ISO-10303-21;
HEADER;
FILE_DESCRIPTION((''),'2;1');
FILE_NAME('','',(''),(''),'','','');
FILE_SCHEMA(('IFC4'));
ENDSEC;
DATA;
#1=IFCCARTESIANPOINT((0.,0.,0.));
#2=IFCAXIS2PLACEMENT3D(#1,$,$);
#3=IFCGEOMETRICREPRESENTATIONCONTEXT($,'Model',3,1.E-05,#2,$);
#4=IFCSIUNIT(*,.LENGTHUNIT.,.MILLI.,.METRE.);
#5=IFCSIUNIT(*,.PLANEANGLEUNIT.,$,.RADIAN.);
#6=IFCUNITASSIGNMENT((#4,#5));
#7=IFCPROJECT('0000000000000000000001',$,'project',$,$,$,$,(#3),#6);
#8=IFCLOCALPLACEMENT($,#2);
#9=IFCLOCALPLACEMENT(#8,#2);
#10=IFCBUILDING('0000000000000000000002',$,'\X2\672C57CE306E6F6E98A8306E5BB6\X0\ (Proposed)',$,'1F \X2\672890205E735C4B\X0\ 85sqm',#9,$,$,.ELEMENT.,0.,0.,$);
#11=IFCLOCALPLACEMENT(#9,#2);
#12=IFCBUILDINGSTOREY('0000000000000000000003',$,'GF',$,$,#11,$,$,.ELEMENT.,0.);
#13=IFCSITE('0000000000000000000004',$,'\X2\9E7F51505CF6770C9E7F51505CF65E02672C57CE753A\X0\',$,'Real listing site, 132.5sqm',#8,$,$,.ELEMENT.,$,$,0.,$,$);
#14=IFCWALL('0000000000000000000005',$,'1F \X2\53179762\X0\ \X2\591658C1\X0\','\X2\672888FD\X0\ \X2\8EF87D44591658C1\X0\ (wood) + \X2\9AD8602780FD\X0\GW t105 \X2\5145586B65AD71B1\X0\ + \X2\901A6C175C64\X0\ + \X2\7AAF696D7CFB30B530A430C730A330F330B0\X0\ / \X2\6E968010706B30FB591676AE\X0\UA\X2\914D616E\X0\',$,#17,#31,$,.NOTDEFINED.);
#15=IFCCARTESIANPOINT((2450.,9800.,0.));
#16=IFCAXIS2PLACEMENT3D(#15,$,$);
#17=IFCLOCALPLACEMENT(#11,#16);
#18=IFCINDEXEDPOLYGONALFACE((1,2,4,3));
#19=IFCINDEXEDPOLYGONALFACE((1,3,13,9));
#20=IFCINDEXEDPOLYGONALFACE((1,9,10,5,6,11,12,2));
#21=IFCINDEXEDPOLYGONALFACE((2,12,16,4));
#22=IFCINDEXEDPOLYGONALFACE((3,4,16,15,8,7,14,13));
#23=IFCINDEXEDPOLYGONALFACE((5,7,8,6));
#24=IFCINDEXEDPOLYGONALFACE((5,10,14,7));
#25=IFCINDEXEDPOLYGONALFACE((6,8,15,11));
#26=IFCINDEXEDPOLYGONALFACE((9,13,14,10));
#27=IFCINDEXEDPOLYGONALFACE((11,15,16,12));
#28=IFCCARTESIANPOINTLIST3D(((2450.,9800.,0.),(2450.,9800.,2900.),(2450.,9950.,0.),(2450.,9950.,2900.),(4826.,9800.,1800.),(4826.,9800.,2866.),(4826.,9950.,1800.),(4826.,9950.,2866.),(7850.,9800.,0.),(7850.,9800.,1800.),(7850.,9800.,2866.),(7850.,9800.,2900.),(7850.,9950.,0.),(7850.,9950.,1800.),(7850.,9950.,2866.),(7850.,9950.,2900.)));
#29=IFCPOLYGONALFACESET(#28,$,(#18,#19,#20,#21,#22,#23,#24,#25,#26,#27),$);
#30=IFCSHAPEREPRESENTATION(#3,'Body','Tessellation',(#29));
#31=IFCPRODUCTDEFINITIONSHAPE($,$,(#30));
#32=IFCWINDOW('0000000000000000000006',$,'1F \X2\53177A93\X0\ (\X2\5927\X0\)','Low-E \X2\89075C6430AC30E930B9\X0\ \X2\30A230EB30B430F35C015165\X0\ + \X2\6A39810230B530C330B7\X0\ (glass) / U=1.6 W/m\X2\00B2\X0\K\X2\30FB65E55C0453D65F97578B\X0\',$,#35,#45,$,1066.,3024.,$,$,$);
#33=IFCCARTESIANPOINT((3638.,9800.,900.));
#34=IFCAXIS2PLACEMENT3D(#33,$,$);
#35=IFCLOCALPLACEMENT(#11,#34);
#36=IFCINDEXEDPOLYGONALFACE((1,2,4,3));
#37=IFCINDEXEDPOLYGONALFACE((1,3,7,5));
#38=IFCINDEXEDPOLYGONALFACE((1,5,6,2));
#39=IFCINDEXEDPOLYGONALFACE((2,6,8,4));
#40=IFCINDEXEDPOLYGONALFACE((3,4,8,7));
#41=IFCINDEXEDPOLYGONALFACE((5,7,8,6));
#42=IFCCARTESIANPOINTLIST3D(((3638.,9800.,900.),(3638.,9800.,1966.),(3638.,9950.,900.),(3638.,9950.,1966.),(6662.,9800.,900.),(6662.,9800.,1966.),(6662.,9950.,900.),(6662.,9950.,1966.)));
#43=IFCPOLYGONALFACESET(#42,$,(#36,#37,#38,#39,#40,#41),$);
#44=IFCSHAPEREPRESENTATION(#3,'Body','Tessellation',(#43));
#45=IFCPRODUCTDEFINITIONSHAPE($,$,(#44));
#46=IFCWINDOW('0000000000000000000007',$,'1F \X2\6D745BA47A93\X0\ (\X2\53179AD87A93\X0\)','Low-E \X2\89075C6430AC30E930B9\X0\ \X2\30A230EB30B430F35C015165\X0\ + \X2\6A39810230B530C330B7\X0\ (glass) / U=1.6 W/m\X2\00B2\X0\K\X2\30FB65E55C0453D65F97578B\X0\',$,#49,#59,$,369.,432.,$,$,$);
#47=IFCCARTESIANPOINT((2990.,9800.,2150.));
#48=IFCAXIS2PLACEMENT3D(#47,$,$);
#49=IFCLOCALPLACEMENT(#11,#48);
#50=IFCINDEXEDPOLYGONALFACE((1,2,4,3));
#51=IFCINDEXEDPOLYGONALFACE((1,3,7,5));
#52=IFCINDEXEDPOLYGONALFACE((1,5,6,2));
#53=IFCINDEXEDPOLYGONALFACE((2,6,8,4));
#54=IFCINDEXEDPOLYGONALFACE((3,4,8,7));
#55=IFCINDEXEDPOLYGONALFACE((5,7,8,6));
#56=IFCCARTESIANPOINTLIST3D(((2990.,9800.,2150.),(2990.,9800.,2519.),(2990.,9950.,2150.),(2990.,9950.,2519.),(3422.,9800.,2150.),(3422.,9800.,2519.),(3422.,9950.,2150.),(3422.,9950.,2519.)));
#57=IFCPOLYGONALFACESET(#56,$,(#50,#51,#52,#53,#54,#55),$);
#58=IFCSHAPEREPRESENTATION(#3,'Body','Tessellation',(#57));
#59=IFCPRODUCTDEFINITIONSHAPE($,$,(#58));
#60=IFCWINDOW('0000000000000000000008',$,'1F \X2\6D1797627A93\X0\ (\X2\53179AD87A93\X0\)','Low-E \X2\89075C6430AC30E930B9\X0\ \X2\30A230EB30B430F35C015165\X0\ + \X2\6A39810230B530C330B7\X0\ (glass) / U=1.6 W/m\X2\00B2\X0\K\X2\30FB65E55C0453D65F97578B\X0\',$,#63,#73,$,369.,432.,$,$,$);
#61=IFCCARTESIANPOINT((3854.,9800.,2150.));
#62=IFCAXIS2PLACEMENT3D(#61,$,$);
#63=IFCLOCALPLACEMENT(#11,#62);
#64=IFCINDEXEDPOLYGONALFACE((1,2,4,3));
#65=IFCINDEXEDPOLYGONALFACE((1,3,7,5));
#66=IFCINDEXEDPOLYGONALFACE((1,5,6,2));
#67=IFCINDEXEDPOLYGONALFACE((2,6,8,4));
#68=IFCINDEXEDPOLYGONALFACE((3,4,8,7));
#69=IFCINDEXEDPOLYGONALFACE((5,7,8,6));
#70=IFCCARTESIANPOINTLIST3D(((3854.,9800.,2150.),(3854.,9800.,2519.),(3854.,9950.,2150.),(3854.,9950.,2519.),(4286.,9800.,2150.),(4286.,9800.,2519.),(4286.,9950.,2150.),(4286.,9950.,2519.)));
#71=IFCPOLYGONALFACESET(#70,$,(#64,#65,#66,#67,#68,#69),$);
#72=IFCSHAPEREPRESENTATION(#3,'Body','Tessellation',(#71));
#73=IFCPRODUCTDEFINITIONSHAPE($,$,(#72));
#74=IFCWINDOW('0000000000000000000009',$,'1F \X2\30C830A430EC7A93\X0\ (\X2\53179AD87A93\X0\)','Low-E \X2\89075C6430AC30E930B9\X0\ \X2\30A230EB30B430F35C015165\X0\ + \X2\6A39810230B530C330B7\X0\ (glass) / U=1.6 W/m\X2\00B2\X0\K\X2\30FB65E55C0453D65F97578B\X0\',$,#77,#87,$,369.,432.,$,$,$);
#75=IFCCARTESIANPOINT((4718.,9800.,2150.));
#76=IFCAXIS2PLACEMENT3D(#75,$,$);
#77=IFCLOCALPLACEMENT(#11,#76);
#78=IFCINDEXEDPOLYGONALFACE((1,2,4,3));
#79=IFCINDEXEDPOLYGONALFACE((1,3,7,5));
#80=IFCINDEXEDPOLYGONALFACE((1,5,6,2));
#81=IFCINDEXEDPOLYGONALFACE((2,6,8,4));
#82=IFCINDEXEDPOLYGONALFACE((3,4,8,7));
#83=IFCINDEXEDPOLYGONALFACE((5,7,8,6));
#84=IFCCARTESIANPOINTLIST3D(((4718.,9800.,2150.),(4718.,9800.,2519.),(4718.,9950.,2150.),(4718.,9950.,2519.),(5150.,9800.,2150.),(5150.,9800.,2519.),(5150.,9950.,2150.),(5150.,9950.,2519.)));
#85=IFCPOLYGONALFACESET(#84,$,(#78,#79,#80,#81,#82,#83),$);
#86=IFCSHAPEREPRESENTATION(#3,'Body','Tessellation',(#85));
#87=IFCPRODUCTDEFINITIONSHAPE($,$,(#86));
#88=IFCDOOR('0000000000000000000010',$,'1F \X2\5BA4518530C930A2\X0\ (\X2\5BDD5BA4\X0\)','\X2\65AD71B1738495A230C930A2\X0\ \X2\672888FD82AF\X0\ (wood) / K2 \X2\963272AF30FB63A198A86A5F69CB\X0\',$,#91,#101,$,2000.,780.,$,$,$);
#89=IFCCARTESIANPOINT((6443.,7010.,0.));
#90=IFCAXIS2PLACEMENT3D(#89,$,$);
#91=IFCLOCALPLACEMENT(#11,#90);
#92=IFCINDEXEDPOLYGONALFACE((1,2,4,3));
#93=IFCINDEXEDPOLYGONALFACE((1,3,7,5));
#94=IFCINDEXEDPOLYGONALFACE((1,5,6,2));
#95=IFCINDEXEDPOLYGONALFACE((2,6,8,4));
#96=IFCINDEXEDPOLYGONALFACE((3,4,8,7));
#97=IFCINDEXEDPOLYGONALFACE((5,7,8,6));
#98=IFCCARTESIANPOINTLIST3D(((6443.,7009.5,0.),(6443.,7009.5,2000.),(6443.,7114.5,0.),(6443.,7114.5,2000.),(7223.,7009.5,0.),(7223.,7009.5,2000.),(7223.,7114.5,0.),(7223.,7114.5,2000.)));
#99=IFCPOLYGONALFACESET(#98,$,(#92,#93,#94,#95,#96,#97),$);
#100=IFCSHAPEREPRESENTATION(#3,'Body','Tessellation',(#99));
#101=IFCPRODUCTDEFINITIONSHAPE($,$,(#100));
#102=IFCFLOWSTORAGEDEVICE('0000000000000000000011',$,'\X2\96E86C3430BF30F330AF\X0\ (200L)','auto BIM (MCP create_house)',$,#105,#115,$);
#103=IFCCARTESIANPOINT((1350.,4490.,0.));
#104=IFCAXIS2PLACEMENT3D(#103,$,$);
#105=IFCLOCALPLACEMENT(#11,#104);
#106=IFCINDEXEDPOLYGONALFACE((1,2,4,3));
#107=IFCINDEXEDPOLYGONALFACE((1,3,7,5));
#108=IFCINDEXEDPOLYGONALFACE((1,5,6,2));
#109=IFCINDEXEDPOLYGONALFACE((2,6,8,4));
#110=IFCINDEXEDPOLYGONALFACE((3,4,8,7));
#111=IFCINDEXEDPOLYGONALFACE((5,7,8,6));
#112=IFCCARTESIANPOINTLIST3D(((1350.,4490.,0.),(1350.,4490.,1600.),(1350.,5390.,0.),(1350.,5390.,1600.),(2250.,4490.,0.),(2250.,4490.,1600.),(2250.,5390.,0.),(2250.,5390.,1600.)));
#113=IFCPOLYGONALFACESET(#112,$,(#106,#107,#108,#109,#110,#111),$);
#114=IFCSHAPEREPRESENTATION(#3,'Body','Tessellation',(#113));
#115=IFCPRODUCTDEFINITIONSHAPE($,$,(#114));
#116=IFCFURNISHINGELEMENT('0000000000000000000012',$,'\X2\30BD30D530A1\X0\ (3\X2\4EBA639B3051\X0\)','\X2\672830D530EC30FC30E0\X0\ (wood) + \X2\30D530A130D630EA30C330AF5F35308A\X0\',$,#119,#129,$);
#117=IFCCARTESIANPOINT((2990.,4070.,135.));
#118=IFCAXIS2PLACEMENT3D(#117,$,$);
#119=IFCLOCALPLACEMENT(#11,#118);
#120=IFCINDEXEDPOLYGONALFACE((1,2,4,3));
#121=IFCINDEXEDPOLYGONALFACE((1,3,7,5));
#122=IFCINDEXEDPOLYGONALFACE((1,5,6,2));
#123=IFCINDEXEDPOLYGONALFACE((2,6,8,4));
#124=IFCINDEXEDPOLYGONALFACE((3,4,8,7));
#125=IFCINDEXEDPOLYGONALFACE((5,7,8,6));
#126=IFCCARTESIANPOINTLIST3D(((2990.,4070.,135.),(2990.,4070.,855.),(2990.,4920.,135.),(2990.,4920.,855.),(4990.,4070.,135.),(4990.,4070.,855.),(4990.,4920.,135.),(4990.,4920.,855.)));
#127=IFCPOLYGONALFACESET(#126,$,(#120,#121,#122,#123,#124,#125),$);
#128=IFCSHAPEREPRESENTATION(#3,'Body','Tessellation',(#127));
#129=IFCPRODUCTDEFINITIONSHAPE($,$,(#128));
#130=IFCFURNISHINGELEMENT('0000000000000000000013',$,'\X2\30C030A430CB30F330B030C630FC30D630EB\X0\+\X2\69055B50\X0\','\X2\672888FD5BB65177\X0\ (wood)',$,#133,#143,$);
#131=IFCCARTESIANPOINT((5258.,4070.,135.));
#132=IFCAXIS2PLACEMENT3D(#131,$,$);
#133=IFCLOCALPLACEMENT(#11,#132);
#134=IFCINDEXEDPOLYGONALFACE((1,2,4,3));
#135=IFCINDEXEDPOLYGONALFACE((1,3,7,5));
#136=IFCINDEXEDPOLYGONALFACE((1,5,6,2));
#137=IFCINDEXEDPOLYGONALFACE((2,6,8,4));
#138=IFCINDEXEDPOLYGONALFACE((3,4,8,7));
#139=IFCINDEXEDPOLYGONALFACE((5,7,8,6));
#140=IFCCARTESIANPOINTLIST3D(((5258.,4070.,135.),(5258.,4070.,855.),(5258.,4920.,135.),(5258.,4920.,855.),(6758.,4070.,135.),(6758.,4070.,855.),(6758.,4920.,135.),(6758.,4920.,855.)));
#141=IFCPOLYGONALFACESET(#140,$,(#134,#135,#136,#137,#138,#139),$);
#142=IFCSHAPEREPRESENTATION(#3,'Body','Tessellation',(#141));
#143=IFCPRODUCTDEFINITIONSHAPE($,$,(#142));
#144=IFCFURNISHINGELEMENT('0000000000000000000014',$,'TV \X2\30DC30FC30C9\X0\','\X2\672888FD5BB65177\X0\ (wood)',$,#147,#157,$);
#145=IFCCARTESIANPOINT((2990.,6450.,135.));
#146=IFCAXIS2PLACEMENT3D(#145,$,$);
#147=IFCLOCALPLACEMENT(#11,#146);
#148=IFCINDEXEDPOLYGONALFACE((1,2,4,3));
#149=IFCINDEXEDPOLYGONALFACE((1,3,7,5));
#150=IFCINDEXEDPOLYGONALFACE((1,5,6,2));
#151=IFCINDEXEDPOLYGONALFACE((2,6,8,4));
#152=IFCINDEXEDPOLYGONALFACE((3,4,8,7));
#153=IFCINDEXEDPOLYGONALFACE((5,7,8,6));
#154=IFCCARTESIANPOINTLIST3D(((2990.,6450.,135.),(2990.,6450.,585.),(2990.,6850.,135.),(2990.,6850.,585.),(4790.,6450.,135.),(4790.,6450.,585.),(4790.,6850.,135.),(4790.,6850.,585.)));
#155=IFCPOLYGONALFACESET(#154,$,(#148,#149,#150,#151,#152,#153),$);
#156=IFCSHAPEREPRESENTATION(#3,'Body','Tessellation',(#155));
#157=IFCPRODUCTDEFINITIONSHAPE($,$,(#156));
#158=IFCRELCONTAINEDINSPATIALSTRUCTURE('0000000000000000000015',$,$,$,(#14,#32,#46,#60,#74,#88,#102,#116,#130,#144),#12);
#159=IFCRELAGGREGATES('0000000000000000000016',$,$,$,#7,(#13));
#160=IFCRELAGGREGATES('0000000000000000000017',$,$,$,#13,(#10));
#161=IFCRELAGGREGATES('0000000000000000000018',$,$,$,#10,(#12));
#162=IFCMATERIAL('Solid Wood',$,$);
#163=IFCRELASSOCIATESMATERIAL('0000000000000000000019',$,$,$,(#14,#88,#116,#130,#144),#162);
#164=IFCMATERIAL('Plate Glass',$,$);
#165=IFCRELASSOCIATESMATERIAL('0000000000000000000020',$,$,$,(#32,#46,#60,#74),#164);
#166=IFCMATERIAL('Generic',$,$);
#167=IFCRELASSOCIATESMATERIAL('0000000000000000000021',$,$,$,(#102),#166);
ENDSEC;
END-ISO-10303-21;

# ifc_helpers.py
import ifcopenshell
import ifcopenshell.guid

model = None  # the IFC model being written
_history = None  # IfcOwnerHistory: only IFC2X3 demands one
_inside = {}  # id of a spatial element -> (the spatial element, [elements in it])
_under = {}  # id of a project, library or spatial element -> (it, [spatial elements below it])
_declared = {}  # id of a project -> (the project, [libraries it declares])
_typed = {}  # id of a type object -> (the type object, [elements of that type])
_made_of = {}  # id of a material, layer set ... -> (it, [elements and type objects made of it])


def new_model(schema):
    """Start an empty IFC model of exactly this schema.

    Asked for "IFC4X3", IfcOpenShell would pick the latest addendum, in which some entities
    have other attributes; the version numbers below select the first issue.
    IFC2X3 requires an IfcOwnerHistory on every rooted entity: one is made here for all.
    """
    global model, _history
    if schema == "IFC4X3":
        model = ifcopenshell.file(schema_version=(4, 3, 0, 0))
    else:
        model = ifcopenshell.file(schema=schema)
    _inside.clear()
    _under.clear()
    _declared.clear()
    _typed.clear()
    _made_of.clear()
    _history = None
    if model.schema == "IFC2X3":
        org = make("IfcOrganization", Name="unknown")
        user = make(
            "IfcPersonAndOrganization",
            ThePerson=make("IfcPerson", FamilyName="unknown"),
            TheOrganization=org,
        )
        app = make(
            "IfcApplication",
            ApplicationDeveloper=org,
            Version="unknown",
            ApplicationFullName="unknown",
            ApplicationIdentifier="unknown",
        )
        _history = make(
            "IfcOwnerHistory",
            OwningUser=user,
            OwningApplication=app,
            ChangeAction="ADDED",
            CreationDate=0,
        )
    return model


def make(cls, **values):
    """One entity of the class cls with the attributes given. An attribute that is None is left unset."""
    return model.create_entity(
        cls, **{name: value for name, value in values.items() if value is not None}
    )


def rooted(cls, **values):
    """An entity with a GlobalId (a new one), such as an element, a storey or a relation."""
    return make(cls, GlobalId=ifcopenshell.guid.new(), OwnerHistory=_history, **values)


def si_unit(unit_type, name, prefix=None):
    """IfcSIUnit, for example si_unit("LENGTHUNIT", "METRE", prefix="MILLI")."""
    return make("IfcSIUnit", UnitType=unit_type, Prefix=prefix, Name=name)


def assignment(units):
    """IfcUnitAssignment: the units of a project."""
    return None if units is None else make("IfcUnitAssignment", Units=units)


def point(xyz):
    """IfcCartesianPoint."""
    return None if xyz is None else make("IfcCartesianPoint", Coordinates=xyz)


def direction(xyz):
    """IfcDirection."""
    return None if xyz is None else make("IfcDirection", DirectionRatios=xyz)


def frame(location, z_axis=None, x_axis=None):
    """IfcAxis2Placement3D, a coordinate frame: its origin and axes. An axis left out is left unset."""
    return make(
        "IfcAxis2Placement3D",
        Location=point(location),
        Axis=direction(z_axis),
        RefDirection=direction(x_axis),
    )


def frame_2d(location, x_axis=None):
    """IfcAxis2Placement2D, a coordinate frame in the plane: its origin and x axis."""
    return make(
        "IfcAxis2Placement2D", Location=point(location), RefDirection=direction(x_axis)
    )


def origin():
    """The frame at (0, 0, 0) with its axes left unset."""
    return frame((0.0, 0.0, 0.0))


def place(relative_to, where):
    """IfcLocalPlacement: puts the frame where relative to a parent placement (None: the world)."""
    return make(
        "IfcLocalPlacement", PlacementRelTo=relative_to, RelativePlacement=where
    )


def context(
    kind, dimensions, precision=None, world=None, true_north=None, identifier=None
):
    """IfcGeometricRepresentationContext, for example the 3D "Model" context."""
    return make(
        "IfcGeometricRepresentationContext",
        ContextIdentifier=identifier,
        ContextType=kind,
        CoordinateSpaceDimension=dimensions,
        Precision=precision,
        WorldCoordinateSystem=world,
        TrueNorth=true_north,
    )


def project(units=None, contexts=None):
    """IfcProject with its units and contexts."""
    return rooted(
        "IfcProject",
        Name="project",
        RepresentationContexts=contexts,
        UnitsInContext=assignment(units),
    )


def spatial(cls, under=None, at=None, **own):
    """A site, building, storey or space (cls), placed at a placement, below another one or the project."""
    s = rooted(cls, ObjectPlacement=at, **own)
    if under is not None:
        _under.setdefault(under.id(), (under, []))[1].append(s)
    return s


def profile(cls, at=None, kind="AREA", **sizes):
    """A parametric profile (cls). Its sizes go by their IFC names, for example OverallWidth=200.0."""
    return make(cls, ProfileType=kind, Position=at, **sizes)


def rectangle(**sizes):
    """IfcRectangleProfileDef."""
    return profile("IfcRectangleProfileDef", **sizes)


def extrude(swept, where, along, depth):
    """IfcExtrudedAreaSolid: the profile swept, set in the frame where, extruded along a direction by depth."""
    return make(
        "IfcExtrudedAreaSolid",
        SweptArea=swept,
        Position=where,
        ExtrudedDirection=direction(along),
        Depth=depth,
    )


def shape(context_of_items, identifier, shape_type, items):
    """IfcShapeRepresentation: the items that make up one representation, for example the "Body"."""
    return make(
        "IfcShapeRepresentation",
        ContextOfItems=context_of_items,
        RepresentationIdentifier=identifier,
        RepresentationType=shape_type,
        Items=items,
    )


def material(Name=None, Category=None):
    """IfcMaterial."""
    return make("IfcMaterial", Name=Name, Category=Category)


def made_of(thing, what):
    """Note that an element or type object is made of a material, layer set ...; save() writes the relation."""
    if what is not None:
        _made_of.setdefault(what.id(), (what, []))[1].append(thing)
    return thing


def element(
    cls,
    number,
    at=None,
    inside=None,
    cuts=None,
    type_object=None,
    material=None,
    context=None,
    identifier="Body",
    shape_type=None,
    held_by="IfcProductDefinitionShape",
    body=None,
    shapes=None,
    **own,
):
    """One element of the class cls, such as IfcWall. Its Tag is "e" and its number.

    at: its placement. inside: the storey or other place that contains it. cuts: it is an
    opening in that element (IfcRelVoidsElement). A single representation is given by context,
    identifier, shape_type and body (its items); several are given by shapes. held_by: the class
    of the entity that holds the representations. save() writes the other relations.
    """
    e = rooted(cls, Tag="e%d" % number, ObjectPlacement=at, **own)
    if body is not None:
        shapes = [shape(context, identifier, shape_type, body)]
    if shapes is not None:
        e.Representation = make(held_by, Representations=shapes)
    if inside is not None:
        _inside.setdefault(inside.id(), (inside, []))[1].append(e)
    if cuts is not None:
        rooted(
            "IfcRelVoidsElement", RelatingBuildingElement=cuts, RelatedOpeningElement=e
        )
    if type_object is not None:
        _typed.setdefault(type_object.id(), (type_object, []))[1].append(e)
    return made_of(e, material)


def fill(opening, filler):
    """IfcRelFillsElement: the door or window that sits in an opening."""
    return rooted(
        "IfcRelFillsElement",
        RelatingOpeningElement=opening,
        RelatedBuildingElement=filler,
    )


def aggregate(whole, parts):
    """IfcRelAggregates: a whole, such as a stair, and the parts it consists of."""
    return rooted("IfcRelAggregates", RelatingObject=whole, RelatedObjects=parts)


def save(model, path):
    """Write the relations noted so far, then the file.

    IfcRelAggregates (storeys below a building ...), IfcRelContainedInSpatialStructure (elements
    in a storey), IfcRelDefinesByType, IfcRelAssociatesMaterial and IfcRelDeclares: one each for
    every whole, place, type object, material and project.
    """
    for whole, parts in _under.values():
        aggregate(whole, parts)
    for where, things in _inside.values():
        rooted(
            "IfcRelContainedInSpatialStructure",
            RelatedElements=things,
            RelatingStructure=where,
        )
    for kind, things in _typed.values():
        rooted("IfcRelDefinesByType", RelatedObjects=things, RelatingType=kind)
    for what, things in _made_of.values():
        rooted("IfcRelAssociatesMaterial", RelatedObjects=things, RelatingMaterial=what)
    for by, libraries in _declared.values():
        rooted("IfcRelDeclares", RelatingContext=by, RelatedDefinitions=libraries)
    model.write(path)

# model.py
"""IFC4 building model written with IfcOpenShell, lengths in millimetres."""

from ifc_helpers import new_model, si_unit, frame, frame_2d, origin, place, context, project, spatial, rectangle, extrude, material, element, fill, save


model = new_model("IFC4")

# Units and contexts
model_context = context("Model", 3, precision=1e-05, world=origin())
ifc_project = project(units=[si_unit("LENGTHUNIT", "METRE", prefix="MILLI"), si_unit("PLANEANGLEUNIT", "RADIAN")], contexts=[model_context])

# Site, building, storey
site_placement = place(None, origin())
site = spatial("IfcSite", under=ifc_project, at=site_placement, Name="鹿児島県鹿児島市本城町", ObjectType="Real listing site, 132.5sqm", CompositionType="ELEMENT", RefElevation=0.0)
building_placement = place(site_placement, origin())
building = spatial("IfcBuilding", under=site, at=building_placement, Name="本城の潮風の家 (Proposed)", ObjectType="1F 木造平屋 85sqm", CompositionType="ELEMENT", ElevationOfRefHeight=0.0, ElevationOfTerrain=0.0)
storey_placement = place(building_placement, origin())
storey = spatial("IfcBuildingStorey", under=building, at=storey_placement, Name="GF", CompositionType="ELEMENT", Elevation=0.0)

# Wall, openings, windows
ifc_material_1 = material(Name="Solid Wood")
wall_1_placement = place(storey_placement, frame((2450.0, 9800.0, 0.0)))
wall_1 = element("IfcWall", 1, at=wall_1_placement, inside=storey, material=ifc_material_1, Name="1F 北面 外壁", Description="木製 軸組外壁 (wood) + 高性能GW t105 充填断熱 + 通気層 + 窯業系サイディング / 準耐火・外皮UA配慮", PredefinedType="NOTDEFINED", context=model_context, shape_type="SweptSolid", body=[
    extrude(rectangle(XDim=5400.0, YDim=150.0, at=frame_2d((2700.0, 75.0))), frame((2450.0, 9800.0, 0.0)), (0.0, 0.0, 1.0), 2900.0),
])
opening_1_placement = place(storey_placement, frame((3638.0, 9800.0, 900.0)))
opening_1 = element("IfcOpeningElement", 2, at=opening_1_placement, cuts=wall_1, PredefinedType="NOTDEFINED", context=model_context, shape_type="SweptSolid", body=[
    extrude(rectangle(XDim=3024.0, YDim=150.0, at=frame_2d((1512.0, 75.0))), frame((3638.0, 9800.0, 900.0)), (0.0, 0.0, 1.0), 1066.0),
])
opening_2_placement = place(storey_placement, frame((2990.0, 9800.0, 2150.0)))
opening_2 = element("IfcOpeningElement", 3, at=opening_2_placement, cuts=wall_1, PredefinedType="NOTDEFINED", context=model_context, shape_type="SweptSolid", body=[
    extrude(rectangle(XDim=432.0, YDim=150.0, at=frame_2d((216.0, 75.0))), frame((2990.0, 9800.0, 2150.0)), (0.0, 0.0, 1.0), 369.0),
])
opening_3_placement = place(storey_placement, frame((3854.0, 9800.0, 2150.0)))
opening_3 = element("IfcOpeningElement", 4, at=opening_3_placement, cuts=wall_1, PredefinedType="NOTDEFINED", context=model_context, shape_type="SweptSolid", body=[
    extrude(rectangle(XDim=432.0, YDim=150.0, at=frame_2d((216.0, 75.0))), frame((3854.0, 9800.0, 2150.0)), (0.0, 0.0, 1.0), 369.0),
])
opening_4_placement = place(storey_placement, frame((4718.0, 9800.0, 2150.0)))
opening_4 = element("IfcOpeningElement", 5, at=opening_4_placement, cuts=wall_1, PredefinedType="NOTDEFINED", context=model_context, shape_type="SweptSolid", body=[
    extrude(rectangle(XDim=432.0, YDim=150.0, at=frame_2d((216.0, 75.0))), frame((4718.0, 9800.0, 2150.0)), (0.0, 0.0, 1.0), 369.0),
])
ifc_material_2 = material(Name="Plate Glass")
window_1_placement = place(storey_placement, frame((3638.0, 9800.0, 900.0)))
window_1 = element("IfcWindow", 6, at=window_1_placement, inside=storey, material=ifc_material_2, Name="1F 北窓 (大)", Description="Low-E 複層ガラス アルゴン封入 + 樹脂サッシ (glass) / U=1.6 W/m²K・日射取得型", OverallHeight=1066.0, OverallWidth=3024.0, context=model_context, shape_type="SweptSolid", body=[
    extrude(rectangle(XDim=3024.0, YDim=150.0, at=frame_2d((1512.0, 75.0))), frame((3638.0, 9800.0, 900.0)), (0.0, 0.0, 1.0), 1066.0),
])
fill(opening_1, window_1)
window_2_placement = place(storey_placement, frame((2990.0, 9800.0, 2150.0)))
window_2 = element("IfcWindow", 7, at=window_2_placement, inside=storey, material=ifc_material_2, Name="1F 浴室窓 (北高窓)", Description="Low-E 複層ガラス アルゴン封入 + 樹脂サッシ (glass) / U=1.6 W/m²K・日射取得型", OverallHeight=369.0, OverallWidth=432.0, context=model_context, shape_type="SweptSolid", body=[
    extrude(rectangle(XDim=432.0, YDim=150.0, at=frame_2d((216.0, 75.0))), frame((2990.0, 9800.0, 2150.0)), (0.0, 0.0, 1.0), 369.0),
])
fill(opening_2, window_2)
window_3_placement = place(storey_placement, frame((3854.0, 9800.0, 2150.0)))
window_3 = element("IfcWindow", 8, at=window_3_placement, inside=storey, material=ifc_material_2, Name="1F 洗面窓 (北高窓)", Description="Low-E 複層ガラス アルゴン封入 + 樹脂サッシ (glass) / U=1.6 W/m²K・日射取得型", OverallHeight=369.0, OverallWidth=432.0, context=model_context, shape_type="SweptSolid", body=[
    extrude(rectangle(XDim=432.0, YDim=150.0, at=frame_2d((216.0, 75.0))), frame((3854.0, 9800.0, 2150.0)), (0.0, 0.0, 1.0), 369.0),
])
fill(opening_3, window_3)
window_4_placement = place(storey_placement, frame((4718.0, 9800.0, 2150.0)))
window_4 = element("IfcWindow", 9, at=window_4_placement, inside=storey, material=ifc_material_2, Name="1F トイレ窓 (北高窓)", Description="Low-E 複層ガラス アルゴン封入 + 樹脂サッシ (glass) / U=1.6 W/m²K・日射取得型", OverallHeight=369.0, OverallWidth=432.0, context=model_context, shape_type="SweptSolid", body=[
    extrude(rectangle(XDim=432.0, YDim=150.0, at=frame_2d((216.0, 75.0))), frame((4718.0, 9800.0, 2150.0)), (0.0, 0.0, 1.0), 369.0),
])
fill(opening_4, window_4)

# Door
door_1_placement = place(storey_placement, frame((6443.0, 7010.0, 0.0)))
element("IfcDoor", 10, at=door_1_placement, inside=storey, material=ifc_material_1, Name="1F 室内ドア (寝室)", Description="断熱玄関ドア 木製芯 (wood) / K2 防犯・採風機構", OverallHeight=2000.0, OverallWidth=780.0, context=model_context, shape_type="SweptSolid", body=[
    extrude(rectangle(XDim=780.0, YDim=105.0, at=frame_2d((390.0, 52.0))), frame((6443.0, 7010.0, 0.0)), (0.0, 0.0, 1.0), 2000.0),
])

# Flow storage device
ifc_material_3 = material(Name="Generic")
flow_storage_device_placement = place(storey_placement, frame((1350.0, 4490.0, 0.0)))
element("IfcFlowStorageDevice", 11, at=flow_storage_device_placement, inside=storey, material=ifc_material_3, Name="雨水タンク (200L)", Description="auto BIM (MCP create_house)", context=model_context, shape_type="SweptSolid", body=[
    extrude(rectangle(XDim=900.0, YDim=900.0, at=frame_2d((450.0, 450.0))), frame((1350.0, 4490.0, 0.0)), (0.0, 0.0, 1.0), 1600.0),
])

# Furnishing elements
furnishing_1_placement = place(storey_placement, frame((2990.0, 4070.0, 135.0)))
element("IfcFurnishingElement", 12, at=furnishing_1_placement, inside=storey, material=ifc_material_1, Name="ソファ (3人掛け)", Description="木フレーム (wood) + ファブリック張り", context=model_context, shape_type="SweptSolid", body=[
    extrude(rectangle(XDim=2000.0, YDim=850.0, at=frame_2d((1000.0, 425.0))), frame((2990.0, 4070.0, 135.0)), (0.0, 0.0, 1.0), 720.0),
])
furnishing_2_placement = place(storey_placement, frame((5258.0, 4070.0, 135.0)))
element("IfcFurnishingElement", 13, at=furnishing_2_placement, inside=storey, material=ifc_material_1, Name="ダイニングテーブル+椅子", Description="木製家具 (wood)", context=model_context, shape_type="SweptSolid", body=[
    extrude(rectangle(XDim=1500.0, YDim=850.0, at=frame_2d((750.0, 425.0))), frame((5258.0, 4070.0, 135.0)), (0.0, 0.0, 1.0), 720.0),
])
furnishing_3_placement = place(storey_placement, frame((2990.0, 6450.0, 135.0)))
element("IfcFurnishingElement", 14, at=furnishing_3_placement, inside=storey, material=ifc_material_1, Name="TV ボード", Description="木製家具 (wood)", context=model_context, shape_type="SweptSolid", body=[
    extrude(rectangle(XDim=1800.0, YDim=400.0, at=frame_2d((900.0, 200.0))), frame((2990.0, 6450.0, 135.0)), (0.0, 0.0, 1.0), 450.0),
])

save(model, "model.ifc")
